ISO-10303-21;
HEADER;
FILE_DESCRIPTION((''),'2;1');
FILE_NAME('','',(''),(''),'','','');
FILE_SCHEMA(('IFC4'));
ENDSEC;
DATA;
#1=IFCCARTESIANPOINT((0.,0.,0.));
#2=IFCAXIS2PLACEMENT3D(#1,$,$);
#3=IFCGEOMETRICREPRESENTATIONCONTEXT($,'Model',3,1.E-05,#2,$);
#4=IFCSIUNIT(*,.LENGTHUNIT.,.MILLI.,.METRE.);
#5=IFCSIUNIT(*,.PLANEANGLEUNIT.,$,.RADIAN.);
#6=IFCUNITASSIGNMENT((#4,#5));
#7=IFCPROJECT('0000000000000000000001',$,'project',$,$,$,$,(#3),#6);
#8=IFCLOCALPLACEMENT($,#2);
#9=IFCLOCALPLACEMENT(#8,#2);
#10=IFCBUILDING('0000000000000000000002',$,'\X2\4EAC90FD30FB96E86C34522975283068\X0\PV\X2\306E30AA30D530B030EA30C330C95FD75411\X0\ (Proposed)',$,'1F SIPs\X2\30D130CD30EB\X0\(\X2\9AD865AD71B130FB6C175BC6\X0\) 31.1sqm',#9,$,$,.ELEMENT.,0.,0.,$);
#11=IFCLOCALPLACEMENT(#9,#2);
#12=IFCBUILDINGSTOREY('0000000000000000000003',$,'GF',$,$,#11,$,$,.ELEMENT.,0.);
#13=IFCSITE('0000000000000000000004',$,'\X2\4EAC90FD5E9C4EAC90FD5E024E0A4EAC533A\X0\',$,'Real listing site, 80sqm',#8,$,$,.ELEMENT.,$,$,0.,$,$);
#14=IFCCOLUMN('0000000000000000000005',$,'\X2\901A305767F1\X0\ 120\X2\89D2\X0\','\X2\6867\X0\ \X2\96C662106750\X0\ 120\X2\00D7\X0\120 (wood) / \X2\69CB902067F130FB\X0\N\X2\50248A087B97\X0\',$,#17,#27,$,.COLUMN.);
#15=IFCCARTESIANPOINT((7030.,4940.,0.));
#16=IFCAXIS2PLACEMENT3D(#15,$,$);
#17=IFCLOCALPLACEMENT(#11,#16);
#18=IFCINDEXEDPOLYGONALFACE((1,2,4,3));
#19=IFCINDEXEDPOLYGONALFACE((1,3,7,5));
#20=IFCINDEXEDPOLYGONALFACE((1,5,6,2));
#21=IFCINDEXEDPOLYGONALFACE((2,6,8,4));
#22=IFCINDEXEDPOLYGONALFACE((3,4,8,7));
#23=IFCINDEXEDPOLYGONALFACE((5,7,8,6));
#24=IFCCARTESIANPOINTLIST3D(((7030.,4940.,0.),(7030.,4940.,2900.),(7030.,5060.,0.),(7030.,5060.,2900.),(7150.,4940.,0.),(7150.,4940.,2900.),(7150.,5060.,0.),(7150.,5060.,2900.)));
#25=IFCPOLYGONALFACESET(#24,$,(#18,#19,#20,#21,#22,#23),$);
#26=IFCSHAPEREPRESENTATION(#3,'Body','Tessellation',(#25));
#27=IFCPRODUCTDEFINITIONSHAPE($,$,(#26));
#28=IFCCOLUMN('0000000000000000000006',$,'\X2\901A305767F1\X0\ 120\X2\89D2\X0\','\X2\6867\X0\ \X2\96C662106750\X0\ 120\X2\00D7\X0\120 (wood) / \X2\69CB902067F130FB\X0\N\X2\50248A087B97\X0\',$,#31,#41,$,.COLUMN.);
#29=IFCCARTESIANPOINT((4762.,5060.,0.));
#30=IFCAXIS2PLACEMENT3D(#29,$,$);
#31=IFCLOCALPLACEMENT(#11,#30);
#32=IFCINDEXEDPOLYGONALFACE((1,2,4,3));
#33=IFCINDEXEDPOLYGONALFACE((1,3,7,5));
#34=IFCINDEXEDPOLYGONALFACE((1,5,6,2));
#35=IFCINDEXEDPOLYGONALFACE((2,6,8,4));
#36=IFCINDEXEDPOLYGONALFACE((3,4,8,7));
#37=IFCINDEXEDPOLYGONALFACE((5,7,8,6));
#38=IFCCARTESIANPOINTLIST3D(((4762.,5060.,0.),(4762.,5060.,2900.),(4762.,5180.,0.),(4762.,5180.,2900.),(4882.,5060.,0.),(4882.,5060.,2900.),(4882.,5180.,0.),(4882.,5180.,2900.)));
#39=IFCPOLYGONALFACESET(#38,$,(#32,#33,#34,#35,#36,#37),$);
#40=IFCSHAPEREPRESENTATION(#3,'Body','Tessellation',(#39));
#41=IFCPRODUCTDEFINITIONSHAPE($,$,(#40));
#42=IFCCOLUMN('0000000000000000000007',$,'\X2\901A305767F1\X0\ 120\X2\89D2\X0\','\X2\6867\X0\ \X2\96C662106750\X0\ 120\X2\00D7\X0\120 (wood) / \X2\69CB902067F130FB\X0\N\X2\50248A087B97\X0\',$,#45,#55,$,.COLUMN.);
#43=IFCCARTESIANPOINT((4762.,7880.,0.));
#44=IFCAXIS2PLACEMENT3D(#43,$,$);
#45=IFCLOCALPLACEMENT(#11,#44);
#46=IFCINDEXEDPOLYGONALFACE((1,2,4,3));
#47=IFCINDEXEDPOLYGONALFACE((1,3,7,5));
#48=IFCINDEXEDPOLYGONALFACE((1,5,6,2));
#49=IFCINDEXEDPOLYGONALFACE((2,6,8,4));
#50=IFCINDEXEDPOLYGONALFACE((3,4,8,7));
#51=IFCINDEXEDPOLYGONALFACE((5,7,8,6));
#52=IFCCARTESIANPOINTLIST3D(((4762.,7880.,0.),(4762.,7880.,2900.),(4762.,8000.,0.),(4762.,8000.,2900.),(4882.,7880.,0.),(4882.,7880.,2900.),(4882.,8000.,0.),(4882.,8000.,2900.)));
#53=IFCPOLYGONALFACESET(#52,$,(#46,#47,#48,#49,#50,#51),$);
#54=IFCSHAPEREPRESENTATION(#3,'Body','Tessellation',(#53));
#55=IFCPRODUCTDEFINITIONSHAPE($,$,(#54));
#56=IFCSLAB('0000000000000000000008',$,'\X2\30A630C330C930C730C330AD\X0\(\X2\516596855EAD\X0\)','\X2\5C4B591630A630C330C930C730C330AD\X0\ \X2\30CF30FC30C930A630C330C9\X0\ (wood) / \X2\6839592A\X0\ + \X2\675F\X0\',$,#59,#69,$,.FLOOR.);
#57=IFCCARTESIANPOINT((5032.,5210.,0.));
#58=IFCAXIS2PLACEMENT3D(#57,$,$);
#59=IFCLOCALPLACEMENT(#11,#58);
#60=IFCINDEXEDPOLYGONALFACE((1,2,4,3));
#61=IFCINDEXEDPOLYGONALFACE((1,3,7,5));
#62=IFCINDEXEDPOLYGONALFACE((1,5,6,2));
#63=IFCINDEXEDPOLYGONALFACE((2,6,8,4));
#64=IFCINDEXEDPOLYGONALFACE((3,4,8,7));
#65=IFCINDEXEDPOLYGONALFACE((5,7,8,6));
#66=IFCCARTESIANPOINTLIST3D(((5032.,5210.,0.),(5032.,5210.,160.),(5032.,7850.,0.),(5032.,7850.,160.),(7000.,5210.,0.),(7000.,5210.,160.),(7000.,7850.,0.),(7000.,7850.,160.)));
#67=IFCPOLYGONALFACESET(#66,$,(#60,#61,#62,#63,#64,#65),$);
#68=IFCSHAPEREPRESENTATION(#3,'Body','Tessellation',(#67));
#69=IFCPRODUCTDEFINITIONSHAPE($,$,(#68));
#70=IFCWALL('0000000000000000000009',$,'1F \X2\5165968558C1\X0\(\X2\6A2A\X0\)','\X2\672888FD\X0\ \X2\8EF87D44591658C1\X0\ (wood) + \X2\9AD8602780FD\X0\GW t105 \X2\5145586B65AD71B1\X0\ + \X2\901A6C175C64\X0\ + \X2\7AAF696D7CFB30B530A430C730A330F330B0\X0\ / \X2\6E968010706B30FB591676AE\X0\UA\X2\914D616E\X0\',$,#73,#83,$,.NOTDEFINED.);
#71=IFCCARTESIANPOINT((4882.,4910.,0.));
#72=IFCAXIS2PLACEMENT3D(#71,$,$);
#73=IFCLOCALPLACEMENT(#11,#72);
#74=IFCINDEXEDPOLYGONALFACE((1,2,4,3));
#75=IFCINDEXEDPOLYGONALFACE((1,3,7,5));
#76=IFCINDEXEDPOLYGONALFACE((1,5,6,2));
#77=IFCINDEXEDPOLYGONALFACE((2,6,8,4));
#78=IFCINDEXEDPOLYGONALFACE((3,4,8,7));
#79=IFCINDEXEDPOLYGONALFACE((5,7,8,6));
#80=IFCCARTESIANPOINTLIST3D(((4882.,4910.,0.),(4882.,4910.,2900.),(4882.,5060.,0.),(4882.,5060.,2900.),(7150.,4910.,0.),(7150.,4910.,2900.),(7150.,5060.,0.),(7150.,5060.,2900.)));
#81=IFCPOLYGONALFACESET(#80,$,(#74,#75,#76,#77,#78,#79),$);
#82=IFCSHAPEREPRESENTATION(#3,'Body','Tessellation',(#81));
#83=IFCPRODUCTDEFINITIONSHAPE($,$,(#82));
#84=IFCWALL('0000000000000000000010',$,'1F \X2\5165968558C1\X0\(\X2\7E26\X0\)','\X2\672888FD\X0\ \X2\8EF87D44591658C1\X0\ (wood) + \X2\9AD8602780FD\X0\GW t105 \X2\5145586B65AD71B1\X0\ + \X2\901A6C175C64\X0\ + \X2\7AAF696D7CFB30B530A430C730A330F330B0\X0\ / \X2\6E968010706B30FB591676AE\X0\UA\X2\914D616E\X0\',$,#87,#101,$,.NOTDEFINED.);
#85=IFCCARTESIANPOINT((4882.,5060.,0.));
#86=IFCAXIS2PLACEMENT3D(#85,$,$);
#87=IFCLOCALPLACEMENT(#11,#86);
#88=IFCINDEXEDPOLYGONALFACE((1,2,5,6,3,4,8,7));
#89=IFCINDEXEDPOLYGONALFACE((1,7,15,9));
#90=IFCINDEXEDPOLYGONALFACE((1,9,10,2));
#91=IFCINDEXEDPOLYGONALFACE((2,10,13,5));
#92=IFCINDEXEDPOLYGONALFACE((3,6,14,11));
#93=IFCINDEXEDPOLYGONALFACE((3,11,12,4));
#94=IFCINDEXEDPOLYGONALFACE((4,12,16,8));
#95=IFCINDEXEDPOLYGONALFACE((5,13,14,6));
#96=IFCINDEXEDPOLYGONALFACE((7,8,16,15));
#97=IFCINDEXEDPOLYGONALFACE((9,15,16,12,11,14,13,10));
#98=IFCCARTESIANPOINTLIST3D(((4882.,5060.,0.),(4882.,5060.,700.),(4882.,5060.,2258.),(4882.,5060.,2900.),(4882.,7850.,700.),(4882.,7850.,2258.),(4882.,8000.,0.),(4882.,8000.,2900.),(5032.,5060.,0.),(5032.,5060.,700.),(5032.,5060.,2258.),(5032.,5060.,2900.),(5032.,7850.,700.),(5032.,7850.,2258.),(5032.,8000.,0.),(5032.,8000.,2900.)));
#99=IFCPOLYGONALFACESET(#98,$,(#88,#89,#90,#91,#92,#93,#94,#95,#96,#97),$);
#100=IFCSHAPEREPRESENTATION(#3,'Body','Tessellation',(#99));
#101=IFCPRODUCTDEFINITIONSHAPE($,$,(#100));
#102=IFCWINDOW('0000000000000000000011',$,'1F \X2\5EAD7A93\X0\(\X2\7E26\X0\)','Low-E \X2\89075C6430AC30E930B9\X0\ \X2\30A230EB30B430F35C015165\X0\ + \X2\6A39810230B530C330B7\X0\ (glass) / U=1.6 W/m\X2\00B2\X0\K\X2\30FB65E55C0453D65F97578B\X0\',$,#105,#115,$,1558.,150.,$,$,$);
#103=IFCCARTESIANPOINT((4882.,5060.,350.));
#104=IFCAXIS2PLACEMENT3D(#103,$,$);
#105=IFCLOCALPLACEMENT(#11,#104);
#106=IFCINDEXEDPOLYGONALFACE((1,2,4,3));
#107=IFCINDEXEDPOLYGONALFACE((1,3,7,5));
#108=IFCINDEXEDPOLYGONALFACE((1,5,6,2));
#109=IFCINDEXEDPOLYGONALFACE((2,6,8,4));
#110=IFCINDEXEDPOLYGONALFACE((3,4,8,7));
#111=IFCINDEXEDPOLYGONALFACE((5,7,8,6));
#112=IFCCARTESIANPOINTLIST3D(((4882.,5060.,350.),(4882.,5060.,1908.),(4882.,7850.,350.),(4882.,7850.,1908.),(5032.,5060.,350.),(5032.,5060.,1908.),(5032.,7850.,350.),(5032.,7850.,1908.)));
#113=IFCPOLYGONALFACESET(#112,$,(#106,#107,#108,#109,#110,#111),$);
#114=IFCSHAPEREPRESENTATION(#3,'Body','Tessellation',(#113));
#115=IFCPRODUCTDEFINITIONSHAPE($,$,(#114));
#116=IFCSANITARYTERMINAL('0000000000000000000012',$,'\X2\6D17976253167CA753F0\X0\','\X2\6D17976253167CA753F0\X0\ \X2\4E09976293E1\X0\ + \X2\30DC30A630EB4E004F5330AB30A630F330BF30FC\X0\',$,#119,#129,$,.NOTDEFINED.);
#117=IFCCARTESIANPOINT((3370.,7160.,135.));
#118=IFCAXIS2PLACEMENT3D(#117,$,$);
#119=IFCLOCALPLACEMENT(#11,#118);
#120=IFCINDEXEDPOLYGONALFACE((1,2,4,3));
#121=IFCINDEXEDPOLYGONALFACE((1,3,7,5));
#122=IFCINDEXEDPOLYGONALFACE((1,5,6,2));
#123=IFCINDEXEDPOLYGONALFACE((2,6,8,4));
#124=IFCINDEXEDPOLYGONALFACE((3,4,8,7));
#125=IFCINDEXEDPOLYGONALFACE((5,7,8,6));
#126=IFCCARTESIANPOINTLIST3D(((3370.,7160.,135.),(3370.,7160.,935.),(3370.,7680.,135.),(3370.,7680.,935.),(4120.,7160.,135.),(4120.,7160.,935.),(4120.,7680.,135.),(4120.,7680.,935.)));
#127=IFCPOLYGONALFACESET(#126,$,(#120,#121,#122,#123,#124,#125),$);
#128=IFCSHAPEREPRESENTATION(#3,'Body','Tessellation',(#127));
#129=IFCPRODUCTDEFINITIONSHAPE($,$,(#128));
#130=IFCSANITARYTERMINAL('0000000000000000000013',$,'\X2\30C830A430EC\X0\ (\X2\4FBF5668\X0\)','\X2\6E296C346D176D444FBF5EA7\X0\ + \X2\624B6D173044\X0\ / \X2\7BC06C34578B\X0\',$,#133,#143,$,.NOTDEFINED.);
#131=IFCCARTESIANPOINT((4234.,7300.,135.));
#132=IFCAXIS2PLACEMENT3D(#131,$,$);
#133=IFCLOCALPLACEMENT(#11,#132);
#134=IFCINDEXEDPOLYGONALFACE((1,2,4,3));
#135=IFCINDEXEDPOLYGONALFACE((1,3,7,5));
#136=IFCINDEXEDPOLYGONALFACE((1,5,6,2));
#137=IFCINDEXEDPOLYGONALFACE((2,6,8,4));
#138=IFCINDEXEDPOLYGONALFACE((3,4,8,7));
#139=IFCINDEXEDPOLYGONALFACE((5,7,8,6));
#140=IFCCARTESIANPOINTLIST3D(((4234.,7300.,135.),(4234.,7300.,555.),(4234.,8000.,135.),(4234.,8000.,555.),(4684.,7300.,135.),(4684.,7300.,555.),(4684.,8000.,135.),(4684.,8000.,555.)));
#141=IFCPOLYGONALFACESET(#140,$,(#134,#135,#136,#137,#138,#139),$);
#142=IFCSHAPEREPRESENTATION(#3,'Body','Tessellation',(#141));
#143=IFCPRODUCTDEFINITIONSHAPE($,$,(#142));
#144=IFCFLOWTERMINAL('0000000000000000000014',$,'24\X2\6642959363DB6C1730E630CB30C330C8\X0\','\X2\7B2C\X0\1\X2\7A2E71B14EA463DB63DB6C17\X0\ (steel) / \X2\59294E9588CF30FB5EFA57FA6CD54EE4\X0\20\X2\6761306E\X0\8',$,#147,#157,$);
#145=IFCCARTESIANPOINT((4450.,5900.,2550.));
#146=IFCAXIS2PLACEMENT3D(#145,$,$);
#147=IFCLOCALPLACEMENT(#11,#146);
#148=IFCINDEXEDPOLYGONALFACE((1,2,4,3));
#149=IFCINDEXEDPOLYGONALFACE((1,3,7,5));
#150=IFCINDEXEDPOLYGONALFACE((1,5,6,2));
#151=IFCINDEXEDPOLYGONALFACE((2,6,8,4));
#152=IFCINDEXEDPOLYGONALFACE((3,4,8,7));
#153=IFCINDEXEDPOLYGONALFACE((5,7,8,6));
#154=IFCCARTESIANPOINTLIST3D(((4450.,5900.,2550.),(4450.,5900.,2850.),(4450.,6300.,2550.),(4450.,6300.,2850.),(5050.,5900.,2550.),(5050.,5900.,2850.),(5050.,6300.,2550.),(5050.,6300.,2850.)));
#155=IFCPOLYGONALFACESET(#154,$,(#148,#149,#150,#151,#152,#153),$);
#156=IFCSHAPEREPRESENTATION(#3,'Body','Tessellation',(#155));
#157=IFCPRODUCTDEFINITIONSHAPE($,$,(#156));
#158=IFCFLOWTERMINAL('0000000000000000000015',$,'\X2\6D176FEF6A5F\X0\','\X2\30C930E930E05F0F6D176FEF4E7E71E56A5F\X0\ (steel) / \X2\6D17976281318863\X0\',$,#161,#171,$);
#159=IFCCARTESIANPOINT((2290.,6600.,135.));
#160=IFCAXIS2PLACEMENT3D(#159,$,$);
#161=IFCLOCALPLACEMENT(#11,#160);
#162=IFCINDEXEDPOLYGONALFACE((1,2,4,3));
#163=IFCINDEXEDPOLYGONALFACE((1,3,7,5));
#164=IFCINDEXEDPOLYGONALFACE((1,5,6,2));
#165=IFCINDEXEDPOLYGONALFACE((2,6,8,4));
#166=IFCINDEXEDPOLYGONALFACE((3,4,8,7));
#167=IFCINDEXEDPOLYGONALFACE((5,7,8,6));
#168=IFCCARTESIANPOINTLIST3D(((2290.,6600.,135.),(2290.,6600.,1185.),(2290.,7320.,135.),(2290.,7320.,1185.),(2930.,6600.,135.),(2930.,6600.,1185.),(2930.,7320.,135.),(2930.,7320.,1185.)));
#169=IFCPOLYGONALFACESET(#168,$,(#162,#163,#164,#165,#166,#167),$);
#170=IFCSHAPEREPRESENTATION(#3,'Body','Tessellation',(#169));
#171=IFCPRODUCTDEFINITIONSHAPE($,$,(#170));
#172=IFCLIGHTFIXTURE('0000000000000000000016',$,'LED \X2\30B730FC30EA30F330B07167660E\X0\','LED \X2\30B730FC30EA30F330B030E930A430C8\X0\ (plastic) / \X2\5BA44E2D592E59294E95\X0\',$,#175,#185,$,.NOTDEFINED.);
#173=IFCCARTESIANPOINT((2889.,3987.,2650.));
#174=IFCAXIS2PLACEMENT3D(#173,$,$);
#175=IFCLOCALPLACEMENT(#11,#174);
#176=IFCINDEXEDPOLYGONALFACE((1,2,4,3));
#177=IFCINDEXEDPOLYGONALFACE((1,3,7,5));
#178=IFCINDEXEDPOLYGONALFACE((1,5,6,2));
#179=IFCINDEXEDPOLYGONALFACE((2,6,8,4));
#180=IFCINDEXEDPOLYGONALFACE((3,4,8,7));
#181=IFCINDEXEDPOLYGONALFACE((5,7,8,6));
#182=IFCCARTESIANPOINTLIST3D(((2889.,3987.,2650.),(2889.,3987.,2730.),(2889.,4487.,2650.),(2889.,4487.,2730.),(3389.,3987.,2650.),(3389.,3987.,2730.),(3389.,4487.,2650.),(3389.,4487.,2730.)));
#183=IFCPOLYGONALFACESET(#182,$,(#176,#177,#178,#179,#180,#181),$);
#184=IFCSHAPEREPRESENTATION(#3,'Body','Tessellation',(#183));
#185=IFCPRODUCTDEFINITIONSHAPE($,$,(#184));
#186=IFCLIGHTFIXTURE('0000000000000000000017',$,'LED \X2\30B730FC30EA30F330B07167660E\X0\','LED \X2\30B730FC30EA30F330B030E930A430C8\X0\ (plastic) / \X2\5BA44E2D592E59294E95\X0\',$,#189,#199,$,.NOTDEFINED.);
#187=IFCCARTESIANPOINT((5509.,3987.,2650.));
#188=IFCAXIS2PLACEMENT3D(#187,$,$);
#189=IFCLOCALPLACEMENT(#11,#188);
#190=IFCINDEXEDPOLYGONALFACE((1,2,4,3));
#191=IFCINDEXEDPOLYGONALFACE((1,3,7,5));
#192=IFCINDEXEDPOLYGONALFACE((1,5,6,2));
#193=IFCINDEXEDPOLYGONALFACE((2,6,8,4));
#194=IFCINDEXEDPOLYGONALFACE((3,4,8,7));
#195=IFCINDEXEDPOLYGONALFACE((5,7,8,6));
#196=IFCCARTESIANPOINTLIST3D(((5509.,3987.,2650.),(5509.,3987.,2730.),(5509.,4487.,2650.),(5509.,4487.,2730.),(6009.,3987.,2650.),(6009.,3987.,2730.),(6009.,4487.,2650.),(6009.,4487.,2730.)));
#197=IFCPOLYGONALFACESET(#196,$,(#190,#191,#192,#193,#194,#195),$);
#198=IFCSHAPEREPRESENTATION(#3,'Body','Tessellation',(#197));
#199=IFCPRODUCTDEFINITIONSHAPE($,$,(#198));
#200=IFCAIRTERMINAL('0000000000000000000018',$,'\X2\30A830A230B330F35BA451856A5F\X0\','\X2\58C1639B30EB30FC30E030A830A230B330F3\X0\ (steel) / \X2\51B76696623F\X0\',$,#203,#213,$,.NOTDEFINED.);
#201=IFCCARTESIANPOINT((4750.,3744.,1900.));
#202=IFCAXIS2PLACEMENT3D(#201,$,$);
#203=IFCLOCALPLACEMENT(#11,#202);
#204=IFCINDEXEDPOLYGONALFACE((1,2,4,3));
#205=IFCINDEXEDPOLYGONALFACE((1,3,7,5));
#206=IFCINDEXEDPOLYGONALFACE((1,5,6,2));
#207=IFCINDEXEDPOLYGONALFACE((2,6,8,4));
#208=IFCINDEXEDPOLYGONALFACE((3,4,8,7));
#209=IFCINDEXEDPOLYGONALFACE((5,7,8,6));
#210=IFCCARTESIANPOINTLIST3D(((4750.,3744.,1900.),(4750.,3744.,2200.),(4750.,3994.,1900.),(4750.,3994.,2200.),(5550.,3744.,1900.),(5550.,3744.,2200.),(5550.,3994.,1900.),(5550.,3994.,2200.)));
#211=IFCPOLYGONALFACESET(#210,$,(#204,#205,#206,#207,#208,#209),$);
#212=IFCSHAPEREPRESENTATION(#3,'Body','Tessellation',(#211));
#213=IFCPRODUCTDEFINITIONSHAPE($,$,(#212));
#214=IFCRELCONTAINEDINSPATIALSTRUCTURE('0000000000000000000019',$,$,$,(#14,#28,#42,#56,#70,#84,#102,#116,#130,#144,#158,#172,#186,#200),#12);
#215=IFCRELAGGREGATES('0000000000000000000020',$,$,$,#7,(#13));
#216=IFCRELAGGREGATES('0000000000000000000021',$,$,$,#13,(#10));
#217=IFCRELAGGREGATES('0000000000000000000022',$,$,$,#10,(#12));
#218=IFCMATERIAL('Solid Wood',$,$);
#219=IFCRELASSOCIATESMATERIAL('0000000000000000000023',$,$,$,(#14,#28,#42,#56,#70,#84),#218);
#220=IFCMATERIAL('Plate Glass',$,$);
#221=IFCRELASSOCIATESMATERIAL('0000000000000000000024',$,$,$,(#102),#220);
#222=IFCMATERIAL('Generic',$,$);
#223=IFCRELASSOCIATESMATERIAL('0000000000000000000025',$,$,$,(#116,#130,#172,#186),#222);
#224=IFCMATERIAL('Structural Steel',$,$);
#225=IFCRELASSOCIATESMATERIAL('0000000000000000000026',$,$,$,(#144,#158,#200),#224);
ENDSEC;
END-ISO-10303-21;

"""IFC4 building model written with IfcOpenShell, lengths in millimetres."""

from ifc_helpers import new_model, si_unit, frame, frame_2d, origin, place, context, project, spatial, rectangle, extrude, material, element, fill, save


model = new_model("IFC4")

# Units and contexts
model_context = context("Model", 3, precision=1e-05, world=origin())
ifc_project = project(units=[si_unit("LENGTHUNIT", "METRE", prefix="MILLI"), si_unit("PLANEANGLEUNIT", "RADIAN")], contexts=[model_context])

# Site, building, storey
site_placement = place(None, origin())
site = spatial("IfcSite", under=ifc_project, at=site_placement, Name="京都府京都市上京区", ObjectType="Real listing site, 80sqm", CompositionType="ELEMENT", RefElevation=0.0)
building_placement = place(site_placement, origin())
building = spatial("IfcBuilding", under=site, at=building_placement, Name="京都・雨水利用とPVのオフグリッド志向 (Proposed)", ObjectType="1F SIPsパネル(高断熱・気密) 31.1sqm", CompositionType="ELEMENT", ElevationOfRefHeight=0.0, ElevationOfTerrain=0.0)
storey_placement = place(building_placement, origin())
storey = spatial("IfcBuildingStorey", under=building, at=storey_placement, Name="GF", CompositionType="ELEMENT", Elevation=0.0)

# Columns
ifc_material_1 = material(Name="Solid Wood")
column_1_placement = place(storey_placement, frame((7030.0, 4940.0, 0.0)))
element("IfcColumn", 1, at=column_1_placement, inside=storey, material=ifc_material_1, Name="通し柱 120角", Description="桧 集成材 120×120 (wood) / 構造柱・N値計算", PredefinedType="COLUMN", context=model_context, shape_type="SweptSolid", body=[
    extrude(rectangle(XDim=120.0, YDim=120.0, at=frame_2d((60.0, 60.0))), frame((7030.0, 4940.0, 0.0)), (0.0, 0.0, 1.0), 2900.0),
])
column_2_placement = place(storey_placement, frame((4762.0, 5060.0, 0.0)))
element("IfcColumn", 2, at=column_2_placement, inside=storey, material=ifc_material_1, Name="通し柱 120角", Description="桧 集成材 120×120 (wood) / 構造柱・N値計算", PredefinedType="COLUMN", context=model_context, shape_type="SweptSolid", body=[
    extrude(rectangle(XDim=120.0, YDim=120.0, at=frame_2d((60.0, 60.0))), frame((4762.0, 5060.0, 0.0)), (0.0, 0.0, 1.0), 2900.0),
])
column_3_placement = place(storey_placement, frame((4762.0, 7880.0, 0.0)))
element("IfcColumn", 3, at=column_3_placement, inside=storey, material=ifc_material_1, Name="通し柱 120角", Description="桧 集成材 120×120 (wood) / 構造柱・N値計算", PredefinedType="COLUMN", context=model_context, shape_type="SweptSolid", body=[
    extrude(rectangle(XDim=120.0, YDim=120.0, at=frame_2d((60.0, 60.0))), frame((4762.0, 7880.0, 0.0)), (0.0, 0.0, 1.0), 2900.0),
])

# Slab
slab_placement = place(storey_placement, frame((5032.0, 5210.0, 0.0)))
element("IfcSlab", 4, at=slab_placement, inside=storey, material=ifc_material_1, Name="ウッドデッキ(入隅庭)", Description="屋外ウッドデッキ ハードウッド (wood) / 根太 + 束", PredefinedType="FLOOR", context=model_context, shape_type="SweptSolid", body=[
    extrude(rectangle(XDim=1968.0, YDim=2640.0, at=frame_2d((984.0, 1320.0))), frame((5032.0, 5210.0, 0.0)), (0.0, 0.0, 1.0), 160.0),
])

# Wall
wall_1_placement = place(storey_placement, frame((4882.0, 4910.0, 0.0)))
element("IfcWall", 5, at=wall_1_placement, inside=storey, material=ifc_material_1, Name="1F 入隅壁(横)", Description="木製 軸組外壁 (wood) + 高性能GW t105 充填断熱 + 通気層 + 窯業系サイディング / 準耐火・外皮UA配慮", PredefinedType="NOTDEFINED", context=model_context, shape_type="SweptSolid", body=[
    extrude(rectangle(XDim=2268.0, YDim=150.0, at=frame_2d((1134.0, 75.0))), frame((4882.0, 4910.0, 0.0)), (0.0, 0.0, 1.0), 2900.0),
])

# Wall, opening, window
wall_2_placement = place(storey_placement, frame((4882.0, 5060.0, 0.0)))
wall_2 = element("IfcWall", 6, at=wall_2_placement, inside=storey, material=ifc_material_1, Name="1F 入隅壁(縦)", Description="木製 軸組外壁 (wood) + 高性能GW t105 充填断熱 + 通気層 + 窯業系サイディング / 準耐火・外皮UA配慮", PredefinedType="NOTDEFINED", context=model_context, shape_type="SweptSolid", body=[
    extrude(rectangle(XDim=150.0, YDim=2940.0, at=frame_2d((75.0, 1470.0))), frame((4882.0, 5060.0, 0.0)), (0.0, 0.0, 1.0), 2900.0),
])
opening_placement = place(storey_placement, frame((4882.0, 5060.0, 350.0)))
opening = element("IfcOpeningElement", 7, at=opening_placement, cuts=wall_2, PredefinedType="NOTDEFINED", context=model_context, shape_type="SweptSolid", body=[
    extrude(rectangle(XDim=150.0, YDim=2790.0, at=frame_2d((75.0, 1395.0))), frame((4882.0, 5060.0, 350.0)), (0.0, 0.0, 1.0), 1558.0),
])
ifc_material_2 = material(Name="Plate Glass")
window_placement = place(storey_placement, frame((4882.0, 5060.0, 350.0)))
window = element("IfcWindow", 8, at=window_placement, inside=storey, material=ifc_material_2, Name="1F 庭窓(縦)", Description="Low-E 複層ガラス アルゴン封入 + 樹脂サッシ (glass) / U=1.6 W/m²K・日射取得型", OverallHeight=1558.0, OverallWidth=150.0, context=model_context, shape_type="SweptSolid", body=[
    extrude(rectangle(XDim=150.0, YDim=2790.0, at=frame_2d((75.0, 1395.0))), frame((4882.0, 5060.0, 350.0)), (0.0, 0.0, 1.0), 1558.0),
])
fill(opening, window)

# Sanitary terminals
ifc_material_3 = material(Name="Generic")
sanitary_terminal_1_placement = place(storey_placement, frame((3370.0, 7160.0, 135.0)))
element("IfcSanitaryTerminal", 9, at=sanitary_terminal_1_placement, inside=storey, material=ifc_material_3, Name="洗面化粧台", Description="洗面化粧台 三面鏡 + ボウル一体カウンター", PredefinedType="NOTDEFINED", context=model_context, shape_type="SweptSolid", body=[
    extrude(rectangle(XDim=750.0, YDim=520.0, at=frame_2d((375.0, 260.0))), frame((3370.0, 7160.0, 135.0)), (0.0, 0.0, 1.0), 800.0),
])
sanitary_terminal_2_placement = place(storey_placement, frame((4234.0, 7300.0, 135.0)))
element("IfcSanitaryTerminal", 10, at=sanitary_terminal_2_placement, inside=storey, material=ifc_material_3, Name="トイレ (便器)", Description="温水洗浄便座 + 手洗い / 節水型", PredefinedType="NOTDEFINED", context=model_context, shape_type="SweptSolid", body=[
    extrude(rectangle(XDim=450.0, YDim=700.0, at=frame_2d((225.0, 350.0))), frame((4234.0, 7300.0, 135.0)), (0.0, 0.0, 1.0), 420.0),
])

# Flow terminals
ifc_material_4 = material(Name="Structural Steel")
flow_terminal_1_placement = place(storey_placement, frame((4450.0, 5900.0, 2550.0)))
element("IfcFlowTerminal", 11, at=flow_terminal_1_placement, inside=storey, material=ifc_material_4, Name="24時間換気ユニット", Description="第1種熱交換換気 (steel) / 天井裏・建基法令20条の8", context=model_context, shape_type="SweptSolid", body=[
    extrude(rectangle(XDim=600.0, YDim=400.0, at=frame_2d((300.0, 200.0))), frame((4450.0, 5900.0, 2550.0)), (0.0, 0.0, 1.0), 300.0),
])
flow_terminal_2_placement = place(storey_placement, frame((2290.0, 6600.0, 135.0)))
element("IfcFlowTerminal", 12, at=flow_terminal_2_placement, inside=storey, material=ifc_material_4, Name="洗濯機", Description="ドラム式洗濯乾燥機 (steel) / 洗面脱衣", context=model_context, shape_type="SweptSolid", body=[
    extrude(rectangle(XDim=640.0, YDim=720.0, at=frame_2d((320.0, 360.0))), frame((2290.0, 6600.0, 135.0)), (0.0, 0.0, 1.0), 1050.0),
])

# Light fixtures
light_fixture_1_placement = place(storey_placement, frame((2889.0, 3987.0, 2650.0)))
element("IfcLightFixture", 13, at=light_fixture_1_placement, inside=storey, material=ifc_material_3, Name="LED シーリング照明", Description="LED シーリングライト (plastic) / 室中央天井", PredefinedType="NOTDEFINED", context=model_context, shape_type="SweptSolid", body=[
    extrude(rectangle(XDim=500.0, YDim=500.0, at=frame_2d((250.0, 250.0))), frame((2889.0, 3987.0, 2650.0)), (0.0, 0.0, 1.0), 80.0),
])
light_fixture_2_placement = place(storey_placement, frame((5509.0, 3987.0, 2650.0)))
element("IfcLightFixture", 14, at=light_fixture_2_placement, inside=storey, material=ifc_material_3, Name="LED シーリング照明", Description="LED シーリングライト (plastic) / 室中央天井", PredefinedType="NOTDEFINED", context=model_context, shape_type="SweptSolid", body=[
    extrude(rectangle(XDim=500.0, YDim=500.0, at=frame_2d((250.0, 250.0))), frame((5509.0, 3987.0, 2650.0)), (0.0, 0.0, 1.0), 80.0),
])

# Air terminal
air_terminal_placement = place(storey_placement, frame((4750.0, 3744.0, 1900.0)))
element("IfcAirTerminal", 15, at=air_terminal_placement, inside=storey, material=ifc_material_4, Name="エアコン室内機", Description="壁掛ルームエアコン (steel) / 冷暖房", PredefinedType="NOTDEFINED", context=model_context, shape_type="SweptSolid", body=[
    extrude(rectangle(XDim=800.0, YDim=250.0, at=frame_2d((400.0, 125.0))), frame((4750.0, 3744.0, 1900.0)), (0.0, 0.0, 1.0), 300.0),
])

save(model, "model.ifc")
